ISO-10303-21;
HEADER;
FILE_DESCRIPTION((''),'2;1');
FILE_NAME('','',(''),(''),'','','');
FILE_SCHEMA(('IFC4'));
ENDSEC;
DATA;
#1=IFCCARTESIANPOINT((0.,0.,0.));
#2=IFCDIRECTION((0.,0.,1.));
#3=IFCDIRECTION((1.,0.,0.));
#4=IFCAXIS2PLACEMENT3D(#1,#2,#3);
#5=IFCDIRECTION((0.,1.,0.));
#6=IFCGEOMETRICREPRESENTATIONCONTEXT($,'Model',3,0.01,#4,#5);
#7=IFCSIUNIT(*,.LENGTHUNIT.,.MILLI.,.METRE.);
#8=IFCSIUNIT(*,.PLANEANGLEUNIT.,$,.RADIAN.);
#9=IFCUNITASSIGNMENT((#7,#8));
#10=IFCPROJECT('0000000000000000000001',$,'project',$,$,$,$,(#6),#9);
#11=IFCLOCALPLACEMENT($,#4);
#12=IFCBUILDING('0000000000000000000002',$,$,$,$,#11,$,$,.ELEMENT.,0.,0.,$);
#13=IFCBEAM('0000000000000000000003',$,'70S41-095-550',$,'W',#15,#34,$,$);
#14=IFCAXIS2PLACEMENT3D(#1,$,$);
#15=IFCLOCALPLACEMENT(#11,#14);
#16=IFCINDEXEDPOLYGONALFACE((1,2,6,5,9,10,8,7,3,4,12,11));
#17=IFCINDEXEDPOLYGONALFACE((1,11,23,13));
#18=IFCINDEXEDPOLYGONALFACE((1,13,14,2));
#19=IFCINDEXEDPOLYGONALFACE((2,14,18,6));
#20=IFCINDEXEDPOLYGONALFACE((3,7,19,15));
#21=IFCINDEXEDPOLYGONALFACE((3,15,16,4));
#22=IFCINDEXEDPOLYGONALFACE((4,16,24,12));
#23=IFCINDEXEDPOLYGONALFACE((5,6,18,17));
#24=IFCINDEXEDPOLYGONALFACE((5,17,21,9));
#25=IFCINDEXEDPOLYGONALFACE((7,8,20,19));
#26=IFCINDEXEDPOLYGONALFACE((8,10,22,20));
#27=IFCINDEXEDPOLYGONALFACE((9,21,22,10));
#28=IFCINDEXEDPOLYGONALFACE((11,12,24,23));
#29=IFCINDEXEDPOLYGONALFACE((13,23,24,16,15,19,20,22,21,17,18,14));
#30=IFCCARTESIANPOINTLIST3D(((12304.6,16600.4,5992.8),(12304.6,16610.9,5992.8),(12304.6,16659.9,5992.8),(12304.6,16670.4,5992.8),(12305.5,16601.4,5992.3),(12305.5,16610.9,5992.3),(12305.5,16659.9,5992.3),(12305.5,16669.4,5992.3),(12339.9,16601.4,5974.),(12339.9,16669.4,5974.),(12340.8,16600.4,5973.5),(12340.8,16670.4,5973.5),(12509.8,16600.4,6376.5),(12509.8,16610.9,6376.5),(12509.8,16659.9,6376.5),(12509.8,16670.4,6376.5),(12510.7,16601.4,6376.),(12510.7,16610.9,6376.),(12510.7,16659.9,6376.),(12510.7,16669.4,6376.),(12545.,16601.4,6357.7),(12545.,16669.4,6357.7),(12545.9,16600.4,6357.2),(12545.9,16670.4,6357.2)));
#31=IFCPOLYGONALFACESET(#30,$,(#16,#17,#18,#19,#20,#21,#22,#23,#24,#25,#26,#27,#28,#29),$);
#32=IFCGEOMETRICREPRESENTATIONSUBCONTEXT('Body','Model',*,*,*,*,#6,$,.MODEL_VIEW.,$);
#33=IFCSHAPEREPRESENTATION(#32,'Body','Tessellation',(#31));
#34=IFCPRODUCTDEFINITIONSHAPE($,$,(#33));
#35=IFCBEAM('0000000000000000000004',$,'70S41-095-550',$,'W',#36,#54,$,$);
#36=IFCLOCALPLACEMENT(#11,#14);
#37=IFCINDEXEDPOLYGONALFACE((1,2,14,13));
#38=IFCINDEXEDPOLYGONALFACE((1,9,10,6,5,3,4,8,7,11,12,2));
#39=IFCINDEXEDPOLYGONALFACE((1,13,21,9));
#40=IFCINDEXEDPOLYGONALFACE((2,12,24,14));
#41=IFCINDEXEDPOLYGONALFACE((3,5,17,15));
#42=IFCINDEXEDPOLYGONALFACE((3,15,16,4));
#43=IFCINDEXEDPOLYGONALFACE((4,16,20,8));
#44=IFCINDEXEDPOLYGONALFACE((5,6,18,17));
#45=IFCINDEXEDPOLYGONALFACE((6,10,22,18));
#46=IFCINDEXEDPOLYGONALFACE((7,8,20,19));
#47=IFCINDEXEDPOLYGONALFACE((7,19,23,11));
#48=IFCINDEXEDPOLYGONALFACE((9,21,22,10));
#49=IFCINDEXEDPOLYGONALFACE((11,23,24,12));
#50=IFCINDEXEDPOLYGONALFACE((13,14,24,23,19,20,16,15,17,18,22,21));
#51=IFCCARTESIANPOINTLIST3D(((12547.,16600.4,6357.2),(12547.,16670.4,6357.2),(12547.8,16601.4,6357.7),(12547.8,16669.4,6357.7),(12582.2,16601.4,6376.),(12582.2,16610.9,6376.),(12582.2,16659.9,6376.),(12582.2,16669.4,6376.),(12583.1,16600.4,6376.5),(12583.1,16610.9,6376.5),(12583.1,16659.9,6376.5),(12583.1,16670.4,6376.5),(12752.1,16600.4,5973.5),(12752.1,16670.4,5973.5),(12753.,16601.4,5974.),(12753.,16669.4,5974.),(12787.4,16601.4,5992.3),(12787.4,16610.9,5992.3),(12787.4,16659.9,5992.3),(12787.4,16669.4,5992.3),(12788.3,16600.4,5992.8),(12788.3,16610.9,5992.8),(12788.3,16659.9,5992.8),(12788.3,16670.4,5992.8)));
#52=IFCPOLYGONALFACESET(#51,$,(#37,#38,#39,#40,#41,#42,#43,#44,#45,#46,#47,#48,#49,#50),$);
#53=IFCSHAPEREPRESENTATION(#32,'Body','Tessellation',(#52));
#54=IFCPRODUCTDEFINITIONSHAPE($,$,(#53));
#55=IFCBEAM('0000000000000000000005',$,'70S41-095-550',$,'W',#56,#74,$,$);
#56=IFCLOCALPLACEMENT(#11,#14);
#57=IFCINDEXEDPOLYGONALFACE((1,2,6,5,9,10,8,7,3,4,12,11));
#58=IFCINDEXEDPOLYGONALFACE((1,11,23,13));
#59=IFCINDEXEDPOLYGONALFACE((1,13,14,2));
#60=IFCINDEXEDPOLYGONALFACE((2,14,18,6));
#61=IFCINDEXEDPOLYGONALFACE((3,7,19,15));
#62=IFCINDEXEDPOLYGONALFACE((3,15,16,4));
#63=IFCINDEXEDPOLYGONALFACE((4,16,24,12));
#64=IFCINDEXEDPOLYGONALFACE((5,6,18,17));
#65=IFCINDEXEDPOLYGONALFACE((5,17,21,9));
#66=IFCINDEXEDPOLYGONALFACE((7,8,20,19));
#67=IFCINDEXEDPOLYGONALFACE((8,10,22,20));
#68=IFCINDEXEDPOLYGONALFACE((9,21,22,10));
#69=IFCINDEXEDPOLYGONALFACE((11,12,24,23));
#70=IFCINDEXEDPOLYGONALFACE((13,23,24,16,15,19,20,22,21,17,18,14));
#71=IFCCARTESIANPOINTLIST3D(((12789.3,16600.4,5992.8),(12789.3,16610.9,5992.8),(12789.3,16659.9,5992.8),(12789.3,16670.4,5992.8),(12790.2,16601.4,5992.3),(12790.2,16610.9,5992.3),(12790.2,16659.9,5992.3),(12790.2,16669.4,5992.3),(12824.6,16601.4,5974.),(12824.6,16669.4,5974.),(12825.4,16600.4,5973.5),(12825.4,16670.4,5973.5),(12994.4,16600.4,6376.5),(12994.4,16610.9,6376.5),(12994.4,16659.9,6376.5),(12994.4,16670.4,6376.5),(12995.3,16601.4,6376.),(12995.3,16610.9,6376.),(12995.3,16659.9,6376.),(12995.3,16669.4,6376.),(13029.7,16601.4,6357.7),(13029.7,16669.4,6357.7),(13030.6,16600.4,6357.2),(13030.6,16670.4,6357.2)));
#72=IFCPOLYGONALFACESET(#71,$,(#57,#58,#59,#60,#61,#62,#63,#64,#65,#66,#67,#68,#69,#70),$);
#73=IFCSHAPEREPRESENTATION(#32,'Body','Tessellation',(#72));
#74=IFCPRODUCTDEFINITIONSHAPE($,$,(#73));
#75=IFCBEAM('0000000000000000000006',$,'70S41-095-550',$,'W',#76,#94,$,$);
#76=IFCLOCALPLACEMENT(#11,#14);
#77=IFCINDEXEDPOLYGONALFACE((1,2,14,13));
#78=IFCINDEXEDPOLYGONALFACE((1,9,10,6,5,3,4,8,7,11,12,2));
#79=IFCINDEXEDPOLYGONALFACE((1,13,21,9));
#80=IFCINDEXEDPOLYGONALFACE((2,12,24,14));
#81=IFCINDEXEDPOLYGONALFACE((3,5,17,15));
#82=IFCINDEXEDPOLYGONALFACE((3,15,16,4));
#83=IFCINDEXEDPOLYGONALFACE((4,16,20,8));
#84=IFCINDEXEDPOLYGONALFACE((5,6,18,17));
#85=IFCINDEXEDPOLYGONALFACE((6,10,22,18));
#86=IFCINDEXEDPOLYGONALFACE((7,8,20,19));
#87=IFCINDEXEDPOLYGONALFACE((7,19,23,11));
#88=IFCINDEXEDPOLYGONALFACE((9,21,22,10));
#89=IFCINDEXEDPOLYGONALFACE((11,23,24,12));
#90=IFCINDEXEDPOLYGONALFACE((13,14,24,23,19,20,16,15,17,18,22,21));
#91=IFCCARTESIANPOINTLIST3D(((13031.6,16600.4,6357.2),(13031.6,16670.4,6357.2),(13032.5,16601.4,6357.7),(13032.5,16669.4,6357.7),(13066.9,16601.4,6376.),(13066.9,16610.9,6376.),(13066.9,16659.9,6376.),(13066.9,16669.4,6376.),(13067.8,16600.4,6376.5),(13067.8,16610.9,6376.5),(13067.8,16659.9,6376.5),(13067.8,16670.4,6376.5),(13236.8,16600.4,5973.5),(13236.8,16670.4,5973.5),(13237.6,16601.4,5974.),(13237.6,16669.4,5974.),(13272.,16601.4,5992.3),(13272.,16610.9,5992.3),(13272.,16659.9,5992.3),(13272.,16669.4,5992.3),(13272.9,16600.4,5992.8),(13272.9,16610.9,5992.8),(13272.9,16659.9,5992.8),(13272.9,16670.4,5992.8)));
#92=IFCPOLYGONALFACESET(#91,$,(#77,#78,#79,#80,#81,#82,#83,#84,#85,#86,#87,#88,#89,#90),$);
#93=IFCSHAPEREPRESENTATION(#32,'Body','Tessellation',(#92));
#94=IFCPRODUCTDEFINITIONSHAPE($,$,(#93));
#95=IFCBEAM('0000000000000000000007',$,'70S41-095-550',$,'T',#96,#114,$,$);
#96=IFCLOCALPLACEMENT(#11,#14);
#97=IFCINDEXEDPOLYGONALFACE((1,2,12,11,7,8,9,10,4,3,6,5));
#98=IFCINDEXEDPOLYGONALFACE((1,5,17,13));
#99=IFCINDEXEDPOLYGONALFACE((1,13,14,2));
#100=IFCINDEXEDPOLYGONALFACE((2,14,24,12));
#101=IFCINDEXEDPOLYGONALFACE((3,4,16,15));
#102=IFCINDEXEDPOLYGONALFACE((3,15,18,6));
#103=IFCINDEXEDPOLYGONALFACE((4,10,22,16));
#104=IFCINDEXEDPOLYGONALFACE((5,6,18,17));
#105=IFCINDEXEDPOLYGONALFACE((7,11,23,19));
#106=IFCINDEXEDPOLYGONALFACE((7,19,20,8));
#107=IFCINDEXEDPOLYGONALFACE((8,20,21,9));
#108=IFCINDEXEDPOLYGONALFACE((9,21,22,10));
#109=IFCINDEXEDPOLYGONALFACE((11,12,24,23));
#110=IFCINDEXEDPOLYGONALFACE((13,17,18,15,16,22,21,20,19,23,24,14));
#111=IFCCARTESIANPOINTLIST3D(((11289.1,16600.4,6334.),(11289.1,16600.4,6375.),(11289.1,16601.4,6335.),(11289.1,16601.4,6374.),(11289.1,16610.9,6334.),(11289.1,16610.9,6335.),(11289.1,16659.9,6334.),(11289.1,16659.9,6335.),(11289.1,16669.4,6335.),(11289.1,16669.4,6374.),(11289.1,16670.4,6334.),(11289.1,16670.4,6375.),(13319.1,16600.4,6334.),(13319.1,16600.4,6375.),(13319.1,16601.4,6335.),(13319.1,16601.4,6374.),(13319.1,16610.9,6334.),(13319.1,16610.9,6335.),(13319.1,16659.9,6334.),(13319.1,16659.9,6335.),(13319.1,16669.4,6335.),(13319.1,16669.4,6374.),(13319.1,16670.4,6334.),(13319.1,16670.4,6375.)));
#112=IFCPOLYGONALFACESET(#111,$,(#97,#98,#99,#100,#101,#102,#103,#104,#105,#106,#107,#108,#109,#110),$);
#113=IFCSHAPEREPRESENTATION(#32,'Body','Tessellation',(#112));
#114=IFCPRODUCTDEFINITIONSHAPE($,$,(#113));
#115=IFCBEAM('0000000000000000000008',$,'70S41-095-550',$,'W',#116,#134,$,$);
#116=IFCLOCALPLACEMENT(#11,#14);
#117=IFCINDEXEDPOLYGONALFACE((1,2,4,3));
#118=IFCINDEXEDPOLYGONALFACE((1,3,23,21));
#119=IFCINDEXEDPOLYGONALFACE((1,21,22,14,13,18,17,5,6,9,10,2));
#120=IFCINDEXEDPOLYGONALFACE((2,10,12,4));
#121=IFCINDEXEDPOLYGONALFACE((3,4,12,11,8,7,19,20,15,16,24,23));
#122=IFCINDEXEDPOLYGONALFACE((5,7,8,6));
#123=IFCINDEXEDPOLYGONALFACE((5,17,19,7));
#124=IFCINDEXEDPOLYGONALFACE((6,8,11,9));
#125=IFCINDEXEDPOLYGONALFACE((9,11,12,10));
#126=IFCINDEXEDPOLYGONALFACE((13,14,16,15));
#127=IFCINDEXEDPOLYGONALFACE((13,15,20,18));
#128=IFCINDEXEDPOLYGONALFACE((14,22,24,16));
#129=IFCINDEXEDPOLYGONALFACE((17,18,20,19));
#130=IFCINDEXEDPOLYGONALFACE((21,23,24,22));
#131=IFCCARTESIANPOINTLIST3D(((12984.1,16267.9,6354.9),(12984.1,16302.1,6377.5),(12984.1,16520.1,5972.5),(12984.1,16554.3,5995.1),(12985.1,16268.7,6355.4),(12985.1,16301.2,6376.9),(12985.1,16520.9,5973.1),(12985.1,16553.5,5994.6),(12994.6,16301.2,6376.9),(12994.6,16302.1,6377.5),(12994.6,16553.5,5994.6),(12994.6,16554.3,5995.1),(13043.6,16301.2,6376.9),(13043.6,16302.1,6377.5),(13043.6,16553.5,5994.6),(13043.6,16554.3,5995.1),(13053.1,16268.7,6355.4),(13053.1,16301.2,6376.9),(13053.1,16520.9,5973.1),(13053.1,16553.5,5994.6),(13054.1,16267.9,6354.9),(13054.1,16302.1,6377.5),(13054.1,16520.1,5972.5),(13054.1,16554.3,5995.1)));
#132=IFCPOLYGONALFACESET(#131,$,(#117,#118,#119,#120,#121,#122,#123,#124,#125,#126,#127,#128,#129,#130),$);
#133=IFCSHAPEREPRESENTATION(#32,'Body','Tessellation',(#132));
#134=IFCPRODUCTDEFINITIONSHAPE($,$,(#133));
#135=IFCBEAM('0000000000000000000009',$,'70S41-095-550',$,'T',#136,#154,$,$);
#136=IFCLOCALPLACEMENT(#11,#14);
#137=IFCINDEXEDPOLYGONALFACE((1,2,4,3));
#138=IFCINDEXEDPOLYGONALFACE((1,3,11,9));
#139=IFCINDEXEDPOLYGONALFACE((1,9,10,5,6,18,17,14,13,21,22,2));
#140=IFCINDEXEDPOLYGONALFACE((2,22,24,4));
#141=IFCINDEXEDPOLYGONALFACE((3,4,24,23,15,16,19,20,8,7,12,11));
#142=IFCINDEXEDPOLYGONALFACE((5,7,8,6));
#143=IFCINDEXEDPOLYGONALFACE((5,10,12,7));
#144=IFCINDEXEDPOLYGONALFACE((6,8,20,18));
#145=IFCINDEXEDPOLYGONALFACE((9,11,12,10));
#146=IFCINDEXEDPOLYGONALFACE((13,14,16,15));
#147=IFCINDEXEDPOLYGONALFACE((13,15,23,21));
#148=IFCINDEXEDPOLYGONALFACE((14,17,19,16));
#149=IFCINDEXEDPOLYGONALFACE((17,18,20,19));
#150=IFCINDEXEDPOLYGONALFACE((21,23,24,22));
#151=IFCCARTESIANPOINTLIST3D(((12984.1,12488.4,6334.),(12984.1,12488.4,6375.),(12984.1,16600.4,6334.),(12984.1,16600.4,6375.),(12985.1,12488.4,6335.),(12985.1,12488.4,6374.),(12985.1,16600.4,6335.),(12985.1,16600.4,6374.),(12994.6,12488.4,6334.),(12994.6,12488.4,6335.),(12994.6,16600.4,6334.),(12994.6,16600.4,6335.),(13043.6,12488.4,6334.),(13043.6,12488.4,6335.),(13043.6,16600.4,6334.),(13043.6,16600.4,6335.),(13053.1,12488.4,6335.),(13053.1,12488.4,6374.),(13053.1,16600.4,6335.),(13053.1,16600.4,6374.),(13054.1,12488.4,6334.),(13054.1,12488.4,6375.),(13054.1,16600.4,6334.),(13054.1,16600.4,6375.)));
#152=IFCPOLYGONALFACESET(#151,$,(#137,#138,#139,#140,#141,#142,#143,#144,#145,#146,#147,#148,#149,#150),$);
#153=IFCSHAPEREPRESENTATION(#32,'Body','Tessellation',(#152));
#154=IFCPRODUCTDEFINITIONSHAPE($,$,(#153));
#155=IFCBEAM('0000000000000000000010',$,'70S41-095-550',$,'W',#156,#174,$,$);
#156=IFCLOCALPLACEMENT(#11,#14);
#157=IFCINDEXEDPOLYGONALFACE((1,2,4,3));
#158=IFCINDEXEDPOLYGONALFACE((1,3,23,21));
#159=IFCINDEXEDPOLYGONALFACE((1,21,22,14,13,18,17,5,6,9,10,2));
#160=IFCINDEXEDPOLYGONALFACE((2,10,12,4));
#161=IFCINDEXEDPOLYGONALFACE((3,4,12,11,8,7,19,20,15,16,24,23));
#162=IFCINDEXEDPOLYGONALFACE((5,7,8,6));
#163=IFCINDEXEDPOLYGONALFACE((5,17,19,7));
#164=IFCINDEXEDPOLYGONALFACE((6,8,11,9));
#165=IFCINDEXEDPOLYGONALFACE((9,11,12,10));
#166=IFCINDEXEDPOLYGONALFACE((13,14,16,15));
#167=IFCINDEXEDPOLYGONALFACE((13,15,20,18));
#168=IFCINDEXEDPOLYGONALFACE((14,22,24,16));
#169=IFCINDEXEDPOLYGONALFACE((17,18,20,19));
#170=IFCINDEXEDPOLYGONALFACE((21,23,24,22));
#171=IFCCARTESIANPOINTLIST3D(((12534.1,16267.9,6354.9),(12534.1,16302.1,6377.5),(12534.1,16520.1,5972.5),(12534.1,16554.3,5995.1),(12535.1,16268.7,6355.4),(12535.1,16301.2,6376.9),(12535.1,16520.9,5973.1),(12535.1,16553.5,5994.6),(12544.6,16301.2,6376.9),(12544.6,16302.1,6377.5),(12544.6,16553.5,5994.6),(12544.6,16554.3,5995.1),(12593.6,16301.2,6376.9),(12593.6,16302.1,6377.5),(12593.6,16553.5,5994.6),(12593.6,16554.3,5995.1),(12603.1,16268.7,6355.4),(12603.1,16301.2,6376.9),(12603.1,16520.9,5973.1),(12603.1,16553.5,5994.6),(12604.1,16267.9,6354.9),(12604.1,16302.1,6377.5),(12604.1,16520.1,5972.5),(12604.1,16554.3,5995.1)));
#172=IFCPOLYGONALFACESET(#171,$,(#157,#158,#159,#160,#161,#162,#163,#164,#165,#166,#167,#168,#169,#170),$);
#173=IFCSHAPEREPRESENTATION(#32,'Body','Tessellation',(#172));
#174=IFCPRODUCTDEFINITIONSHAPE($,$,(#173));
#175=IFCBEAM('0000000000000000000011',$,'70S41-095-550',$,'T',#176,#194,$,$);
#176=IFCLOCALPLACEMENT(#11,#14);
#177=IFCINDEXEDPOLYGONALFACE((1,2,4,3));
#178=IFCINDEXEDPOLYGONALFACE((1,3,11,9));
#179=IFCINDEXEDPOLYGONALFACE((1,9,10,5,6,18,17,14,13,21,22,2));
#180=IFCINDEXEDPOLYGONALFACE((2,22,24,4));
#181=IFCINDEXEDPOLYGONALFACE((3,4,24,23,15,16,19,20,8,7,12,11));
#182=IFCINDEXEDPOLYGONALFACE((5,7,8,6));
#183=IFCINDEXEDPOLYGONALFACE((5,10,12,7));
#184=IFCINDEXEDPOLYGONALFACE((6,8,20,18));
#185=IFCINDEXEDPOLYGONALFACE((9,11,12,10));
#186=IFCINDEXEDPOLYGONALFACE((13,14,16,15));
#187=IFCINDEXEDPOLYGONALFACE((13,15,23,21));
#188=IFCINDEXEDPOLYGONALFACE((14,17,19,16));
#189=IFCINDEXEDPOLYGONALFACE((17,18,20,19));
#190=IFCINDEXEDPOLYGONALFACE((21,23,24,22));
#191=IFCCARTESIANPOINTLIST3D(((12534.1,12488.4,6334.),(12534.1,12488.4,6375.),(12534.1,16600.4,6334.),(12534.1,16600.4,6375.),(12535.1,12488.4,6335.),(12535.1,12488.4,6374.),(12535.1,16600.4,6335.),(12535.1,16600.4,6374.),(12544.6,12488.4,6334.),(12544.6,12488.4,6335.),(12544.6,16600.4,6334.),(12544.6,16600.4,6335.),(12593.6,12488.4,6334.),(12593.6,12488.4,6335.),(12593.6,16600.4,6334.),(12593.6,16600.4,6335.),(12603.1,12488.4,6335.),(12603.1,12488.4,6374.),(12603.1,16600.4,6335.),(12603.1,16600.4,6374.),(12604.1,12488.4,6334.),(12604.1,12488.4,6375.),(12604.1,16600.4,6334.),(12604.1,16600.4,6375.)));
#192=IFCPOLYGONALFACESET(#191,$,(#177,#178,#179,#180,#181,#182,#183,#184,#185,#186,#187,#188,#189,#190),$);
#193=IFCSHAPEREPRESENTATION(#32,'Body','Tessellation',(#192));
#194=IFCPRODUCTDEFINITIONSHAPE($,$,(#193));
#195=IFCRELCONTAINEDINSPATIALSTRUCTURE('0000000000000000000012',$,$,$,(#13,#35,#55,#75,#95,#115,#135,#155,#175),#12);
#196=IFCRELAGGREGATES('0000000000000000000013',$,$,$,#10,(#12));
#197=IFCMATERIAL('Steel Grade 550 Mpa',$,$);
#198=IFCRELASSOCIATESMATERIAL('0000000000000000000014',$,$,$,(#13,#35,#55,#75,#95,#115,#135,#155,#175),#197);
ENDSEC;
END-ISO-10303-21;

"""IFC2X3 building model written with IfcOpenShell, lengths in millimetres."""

from ifc_helpers import new_model, si_unit, direction, frame, origin, origin_with_axes, origin_2d_with_axis, place, context, subcontext, project, spatial, c_section, extrude, source, transform, mapped, material, element, save


model = new_model("IFC2X3")

# Units and contexts
model_context = context("Model", 3, precision=0.01, world=origin_with_axes(), true_north=direction((0.0, 1.0, 0.0)))
body_context = subcontext(model_context, "Body", "Model", "MODEL_VIEW")
ifc_project = project(units=[si_unit("LENGTHUNIT", "METRE", prefix="MILLI"), si_unit("PLANEANGLEUNIT", "RADIAN")], contexts=[model_context])

# Building
building_placement = place(None, origin_with_axes())
building = spatial("IfcBuilding", under=ifc_project, at=building_placement, CompositionType="ELEMENT", ElevationOfRefHeight=0.0, ElevationOfTerrain=0.0)

# Shared definitions
ifc_material = material(Name="Steel Grade 550 Mpa")

# Beams
shared_shape_1 = source(origin(), body_context, "Body", "SweptSolid", [
    extrude(c_section(Depth=70.0, Width=41.0, WallThickness=1.0, Girth=10.5, at=origin_2d_with_axis()), origin_with_axes(), (0.0, 0.0, 1.0), 435.1),
])
beam_1_placement = place(None, frame((12527.9, 16635.4, 6366.8), z_axis=(-0.471488, 0.0, -0.881872), x_axis=(-0.881872, 0.0, 0.471488)))
element("IfcBeam", 1, at=beam_1_placement, inside=building, material=ifc_material, Name="70S41-095-550", ObjectType="W", context=body_context, shape_type="MappedRepresentation", body=[
    mapped(shared_shape_1, transform((0.0, 0.0, 0.0), scale=1.0)),
])
shared_shape_2 = source(origin(), body_context, "Body", "SweptSolid", [
    extrude(c_section(Depth=70.0, Width=41.0, WallThickness=1.0, Girth=10.5, at=origin_2d_with_axis()), origin_with_axes(), (0.0, 0.0, 1.0), 435.1),
])
beam_2_placement = place(None, frame((12770.2, 16635.4, 5983.2), z_axis=(-0.471488, 0.0, 0.881872), x_axis=(0.881872, 0.0, 0.471488)))
element("IfcBeam", 2, at=beam_2_placement, inside=building, material=ifc_material, Name="70S41-095-550", ObjectType="W", context=body_context, shape_type="MappedRepresentation", body=[
    mapped(shared_shape_2, transform((0.0, 0.0, 0.0), scale=1.0)),
])
shared_shape_3 = source(origin(), body_context, "Body", "SweptSolid", [
    extrude(c_section(Depth=70.0, Width=41.0, WallThickness=1.0, Girth=10.5, at=origin_2d_with_axis()), origin_with_axes(), (0.0, 0.0, 1.0), 435.1),
])
beam_3_placement = place(None, frame((13012.5, 16635.4, 6366.8), z_axis=(-0.471488, 0.0, -0.881872), x_axis=(-0.881872, 0.0, 0.471488)))
element("IfcBeam", 3, at=beam_3_placement, inside=building, material=ifc_material, Name="70S41-095-550", ObjectType="W", context=body_context, shape_type="MappedRepresentation", body=[
    mapped(shared_shape_3, transform((0.0, 0.0, 0.0), scale=1.0)),
])
shared_shape_4 = source(origin(), body_context, "Body", "SweptSolid", [
    extrude(c_section(Depth=70.0, Width=41.0, WallThickness=1.0, Girth=10.5, at=origin_2d_with_axis()), origin_with_axes(), (0.0, 0.0, 1.0), 435.1),
])
beam_4_placement = place(None, frame((13254.8, 16635.4, 5983.2), z_axis=(-0.471488, 0.0, 0.881872), x_axis=(0.881872, 0.0, 0.471488)))
element("IfcBeam", 4, at=beam_4_placement, inside=building, material=ifc_material, Name="70S41-095-550", ObjectType="W", context=body_context, shape_type="MappedRepresentation", body=[
    mapped(shared_shape_4, transform((0.0, 0.0, 0.0), scale=1.0)),
])
shared_shape_5 = source(origin(), body_context, "Body", "SweptSolid", [
    extrude(c_section(Depth=70.0, Width=41.0, WallThickness=1.0, Girth=10.5, at=origin_2d_with_axis()), origin_with_axes(), (0.0, 0.0, 1.0), 2030.0),
])
beam_5_placement = place(None, frame((11289.1, 16635.4, 6354.5), z_axis=(1.0, 0.0, 0.0), x_axis=(0.0, 0.0, -1.0)))
element("IfcBeam", 5, at=beam_5_placement, inside=building, material=ifc_material, Name="70S41-095-550", ObjectType="T", context=body_context, shape_type="MappedRepresentation", body=[
    mapped(shared_shape_5, transform((0.0, 0.0, 0.0), scale=1.0)),
])
shared_shape_6 = source(origin(), body_context, "Body", "SweptSolid", [
    extrude(c_section(Depth=70.0, Width=41.0, WallThickness=1.0, Girth=10.5, at=origin_2d_with_axis()), origin_with_axes(), (0.0, 0.0, 1.0), 458.1),
])
beam_6_placement = place(None, frame((13019.1, 16285.0, 6366.2), z_axis=(0.0, 0.550611, -0.834762), x_axis=(0.0, 0.834762, 0.550611)))
element("IfcBeam", 6, at=beam_6_placement, inside=building, material=ifc_material, Name="70S41-095-550", ObjectType="W", context=body_context, shape_type="MappedRepresentation", body=[
    mapped(shared_shape_6, transform((0.0, 0.0, 0.0), scale=1.0)),
])
shared_shape_7 = source(origin(), body_context, "Body", "SweptSolid", [
    extrude(c_section(Depth=70.0, Width=41.0, WallThickness=1.0, Girth=10.5, at=origin_2d_with_axis()), origin_with_axes(), (0.0, 0.0, 1.0), 4112.0),
])
beam_7_placement = place(None, frame((13019.1, 16600.4, 6354.5), z_axis=(0.0, -1.0, 0.0), x_axis=(0.0, 0.0, -1.0)))
element("IfcBeam", 7, at=beam_7_placement, inside=building, material=ifc_material, Name="70S41-095-550", ObjectType="T", context=body_context, shape_type="MappedRepresentation", body=[
    mapped(shared_shape_7, transform((0.0, 0.0, 0.0), scale=1.0)),
])
shared_shape_8 = source(origin(), body_context, "Body", "SweptSolid", [
    extrude(c_section(Depth=70.0, Width=41.0, WallThickness=1.0, Girth=10.5, at=origin_2d_with_axis()), origin_with_axes(), (0.0, 0.0, 1.0), 458.1),
])
beam_8_placement = place(None, frame((12569.1, 16285.0, 6366.2), z_axis=(0.0, 0.550611, -0.834762), x_axis=(0.0, 0.834762, 0.550611)))
element("IfcBeam", 8, at=beam_8_placement, inside=building, material=ifc_material, Name="70S41-095-550", ObjectType="W", context=body_context, shape_type="MappedRepresentation", body=[
    mapped(shared_shape_8, transform((0.0, 0.0, 0.0), scale=1.0)),
])
shared_shape_9 = source(origin(), body_context, "Body", "SweptSolid", [
    extrude(c_section(Depth=70.0, Width=41.0, WallThickness=1.0, Girth=10.5, at=origin_2d_with_axis()), origin_with_axes(), (0.0, 0.0, 1.0), 4112.0),
])
beam_9_placement = place(None, frame((12569.1, 16600.4, 6354.5), z_axis=(0.0, -1.0, 0.0), x_axis=(0.0, 0.0, -1.0)))
element("IfcBeam", 9, at=beam_9_placement, inside=building, material=ifc_material, Name="70S41-095-550", ObjectType="T", context=body_context, shape_type="MappedRepresentation", body=[
    mapped(shared_shape_9, transform((0.0, 0.0, 0.0), scale=1.0)),
])

save(model, "model.ifc")
